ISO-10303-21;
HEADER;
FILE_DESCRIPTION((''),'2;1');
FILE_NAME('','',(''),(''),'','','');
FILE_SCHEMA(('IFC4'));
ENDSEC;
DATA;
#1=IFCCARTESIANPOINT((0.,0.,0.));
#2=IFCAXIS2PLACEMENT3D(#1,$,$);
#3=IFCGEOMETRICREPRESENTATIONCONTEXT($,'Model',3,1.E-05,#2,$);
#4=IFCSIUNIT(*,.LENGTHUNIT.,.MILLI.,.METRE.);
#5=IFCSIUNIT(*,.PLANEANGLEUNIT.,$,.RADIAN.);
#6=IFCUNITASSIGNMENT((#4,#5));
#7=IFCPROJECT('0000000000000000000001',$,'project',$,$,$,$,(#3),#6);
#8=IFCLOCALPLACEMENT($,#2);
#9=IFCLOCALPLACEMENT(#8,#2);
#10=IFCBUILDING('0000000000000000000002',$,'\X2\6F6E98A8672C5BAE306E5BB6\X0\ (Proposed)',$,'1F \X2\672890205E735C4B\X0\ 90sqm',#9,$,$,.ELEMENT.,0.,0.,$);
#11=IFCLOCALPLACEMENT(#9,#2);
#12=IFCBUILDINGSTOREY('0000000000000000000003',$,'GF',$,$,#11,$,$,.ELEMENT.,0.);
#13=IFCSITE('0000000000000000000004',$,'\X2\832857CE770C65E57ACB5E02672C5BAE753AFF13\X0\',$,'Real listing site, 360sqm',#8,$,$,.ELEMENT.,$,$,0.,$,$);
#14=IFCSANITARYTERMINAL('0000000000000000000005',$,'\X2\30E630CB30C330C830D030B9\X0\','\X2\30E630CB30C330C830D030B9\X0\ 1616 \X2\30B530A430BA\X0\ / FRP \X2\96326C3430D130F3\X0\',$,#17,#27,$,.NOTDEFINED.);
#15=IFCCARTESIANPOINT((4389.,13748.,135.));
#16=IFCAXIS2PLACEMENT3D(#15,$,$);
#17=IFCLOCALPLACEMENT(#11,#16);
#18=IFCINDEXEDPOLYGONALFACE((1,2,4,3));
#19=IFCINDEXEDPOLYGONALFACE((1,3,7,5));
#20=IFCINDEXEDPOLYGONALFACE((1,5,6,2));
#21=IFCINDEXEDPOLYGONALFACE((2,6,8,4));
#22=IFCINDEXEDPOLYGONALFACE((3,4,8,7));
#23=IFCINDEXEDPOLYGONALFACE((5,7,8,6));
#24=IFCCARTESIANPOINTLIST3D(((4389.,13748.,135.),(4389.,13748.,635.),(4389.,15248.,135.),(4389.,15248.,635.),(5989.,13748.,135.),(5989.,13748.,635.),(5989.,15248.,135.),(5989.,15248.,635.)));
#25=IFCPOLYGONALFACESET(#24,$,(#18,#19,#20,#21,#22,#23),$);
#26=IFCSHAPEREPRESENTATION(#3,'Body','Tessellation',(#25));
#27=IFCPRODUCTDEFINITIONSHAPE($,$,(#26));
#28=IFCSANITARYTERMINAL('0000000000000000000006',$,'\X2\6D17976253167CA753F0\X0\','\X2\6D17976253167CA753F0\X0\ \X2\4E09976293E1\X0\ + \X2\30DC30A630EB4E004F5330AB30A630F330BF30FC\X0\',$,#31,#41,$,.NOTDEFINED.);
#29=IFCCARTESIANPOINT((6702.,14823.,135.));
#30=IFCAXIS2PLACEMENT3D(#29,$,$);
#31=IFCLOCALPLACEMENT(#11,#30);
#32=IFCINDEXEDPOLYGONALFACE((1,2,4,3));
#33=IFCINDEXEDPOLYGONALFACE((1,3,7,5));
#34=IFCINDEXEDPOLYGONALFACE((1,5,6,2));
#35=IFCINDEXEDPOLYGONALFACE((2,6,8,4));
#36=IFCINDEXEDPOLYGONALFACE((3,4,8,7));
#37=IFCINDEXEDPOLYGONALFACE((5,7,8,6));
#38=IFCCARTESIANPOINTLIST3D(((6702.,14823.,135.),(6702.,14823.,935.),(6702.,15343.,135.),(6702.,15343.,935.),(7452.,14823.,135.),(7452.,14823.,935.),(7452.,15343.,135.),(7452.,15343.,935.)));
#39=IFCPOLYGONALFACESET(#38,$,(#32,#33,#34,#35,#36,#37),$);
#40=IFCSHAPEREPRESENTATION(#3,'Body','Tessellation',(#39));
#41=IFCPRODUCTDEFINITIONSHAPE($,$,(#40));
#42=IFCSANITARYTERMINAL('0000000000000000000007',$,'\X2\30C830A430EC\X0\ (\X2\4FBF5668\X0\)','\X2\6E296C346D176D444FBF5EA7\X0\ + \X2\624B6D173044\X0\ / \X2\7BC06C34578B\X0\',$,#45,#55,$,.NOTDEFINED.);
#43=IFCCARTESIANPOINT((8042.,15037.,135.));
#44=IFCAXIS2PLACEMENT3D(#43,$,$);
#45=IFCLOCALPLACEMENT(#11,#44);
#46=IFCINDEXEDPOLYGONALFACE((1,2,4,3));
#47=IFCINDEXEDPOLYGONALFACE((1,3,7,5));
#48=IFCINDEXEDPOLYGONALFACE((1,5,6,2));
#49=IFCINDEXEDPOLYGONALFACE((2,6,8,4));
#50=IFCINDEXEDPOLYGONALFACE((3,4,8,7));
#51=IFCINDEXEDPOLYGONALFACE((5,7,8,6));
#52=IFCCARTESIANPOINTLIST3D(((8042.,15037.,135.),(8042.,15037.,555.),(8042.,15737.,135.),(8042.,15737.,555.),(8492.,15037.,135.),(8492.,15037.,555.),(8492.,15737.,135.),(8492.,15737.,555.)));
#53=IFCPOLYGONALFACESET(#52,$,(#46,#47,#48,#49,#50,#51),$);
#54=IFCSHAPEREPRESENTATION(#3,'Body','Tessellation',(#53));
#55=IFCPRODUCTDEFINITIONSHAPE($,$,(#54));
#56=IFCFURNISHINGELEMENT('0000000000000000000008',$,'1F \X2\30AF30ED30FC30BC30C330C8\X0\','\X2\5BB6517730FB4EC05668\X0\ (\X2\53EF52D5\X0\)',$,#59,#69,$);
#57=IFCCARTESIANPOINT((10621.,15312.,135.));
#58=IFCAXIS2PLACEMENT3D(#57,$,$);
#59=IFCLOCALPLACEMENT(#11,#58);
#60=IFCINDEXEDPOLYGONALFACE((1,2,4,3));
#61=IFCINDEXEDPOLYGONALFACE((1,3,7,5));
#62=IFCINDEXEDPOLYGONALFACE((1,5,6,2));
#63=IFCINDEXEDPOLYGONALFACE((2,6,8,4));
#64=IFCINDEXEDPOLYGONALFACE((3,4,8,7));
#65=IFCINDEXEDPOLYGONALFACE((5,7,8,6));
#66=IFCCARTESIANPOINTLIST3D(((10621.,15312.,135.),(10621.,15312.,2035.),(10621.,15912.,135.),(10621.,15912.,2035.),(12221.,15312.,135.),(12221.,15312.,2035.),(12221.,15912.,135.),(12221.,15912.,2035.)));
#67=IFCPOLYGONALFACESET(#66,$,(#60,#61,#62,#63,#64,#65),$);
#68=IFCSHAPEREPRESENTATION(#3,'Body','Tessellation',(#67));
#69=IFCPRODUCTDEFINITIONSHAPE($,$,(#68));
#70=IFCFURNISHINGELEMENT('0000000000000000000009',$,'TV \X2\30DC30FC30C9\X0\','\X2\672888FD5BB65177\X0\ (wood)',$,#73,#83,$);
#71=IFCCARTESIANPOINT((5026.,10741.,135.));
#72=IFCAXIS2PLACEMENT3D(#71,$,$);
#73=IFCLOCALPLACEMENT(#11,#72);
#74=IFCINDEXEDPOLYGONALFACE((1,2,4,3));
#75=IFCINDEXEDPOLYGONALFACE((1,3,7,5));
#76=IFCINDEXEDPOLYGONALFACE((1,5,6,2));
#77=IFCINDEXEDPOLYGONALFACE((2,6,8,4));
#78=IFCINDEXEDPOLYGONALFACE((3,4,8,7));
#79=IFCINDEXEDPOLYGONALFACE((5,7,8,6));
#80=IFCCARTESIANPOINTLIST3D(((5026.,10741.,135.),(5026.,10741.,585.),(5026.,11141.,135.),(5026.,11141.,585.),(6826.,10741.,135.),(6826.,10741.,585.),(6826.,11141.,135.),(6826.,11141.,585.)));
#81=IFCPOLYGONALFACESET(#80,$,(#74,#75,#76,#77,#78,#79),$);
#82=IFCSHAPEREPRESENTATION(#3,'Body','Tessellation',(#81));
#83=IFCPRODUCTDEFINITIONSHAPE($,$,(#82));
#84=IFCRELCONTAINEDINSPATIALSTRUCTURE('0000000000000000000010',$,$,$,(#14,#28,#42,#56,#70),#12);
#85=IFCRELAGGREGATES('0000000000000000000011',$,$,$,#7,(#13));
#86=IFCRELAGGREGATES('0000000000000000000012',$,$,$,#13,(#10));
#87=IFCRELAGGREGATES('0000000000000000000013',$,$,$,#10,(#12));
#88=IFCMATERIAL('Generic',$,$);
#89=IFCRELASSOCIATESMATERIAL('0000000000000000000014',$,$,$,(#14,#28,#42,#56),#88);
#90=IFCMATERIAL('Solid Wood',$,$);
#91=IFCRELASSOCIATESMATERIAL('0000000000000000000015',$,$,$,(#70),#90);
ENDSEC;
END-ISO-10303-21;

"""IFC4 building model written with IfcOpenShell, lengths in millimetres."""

from ifc_helpers import new_model, si_unit, frame, frame_2d, origin, place, context, project, spatial, rectangle, extrude, material, element, save


model = new_model("IFC4")

# Units and contexts
model_context = context("Model", 3, precision=1e-05, world=origin())
ifc_project = project(units=[si_unit("LENGTHUNIT", "METRE", prefix="MILLI"), si_unit("PLANEANGLEUNIT", "RADIAN")], contexts=[model_context])

# Site, building, storey
site_placement = place(None, origin())
site = spatial("IfcSite", under=ifc_project, at=site_placement, Name="茨城県日立市本宮町３", ObjectType="Real listing site, 360sqm", CompositionType="ELEMENT", RefElevation=0.0)
building_placement = place(site_placement, origin())
building = spatial("IfcBuilding", under=site, at=building_placement, Name="潮風本宮の家 (Proposed)", ObjectType="1F 木造平屋 90sqm", CompositionType="ELEMENT", ElevationOfRefHeight=0.0, ElevationOfTerrain=0.0)
storey_placement = place(building_placement, origin())
storey = spatial("IfcBuildingStorey", under=building, at=storey_placement, Name="GF", CompositionType="ELEMENT", Elevation=0.0)

# Shared definitions
ifc_material_1 = material(Name="Solid Wood")

# Sanitary terminals
ifc_material_2 = material(Name="Generic")
sanitary_terminal_1_placement = place(storey_placement, frame((4389.0, 13748.0, 135.0)))
element("IfcSanitaryTerminal", 1, at=sanitary_terminal_1_placement, inside=storey, material=ifc_material_2, Name="ユニットバス", Description="ユニットバス 1616 サイズ / FRP 防水パン", PredefinedType="NOTDEFINED", context=model_context, shape_type="SweptSolid", body=[
    extrude(rectangle(XDim=1600.0, YDim=1500.0, at=frame_2d((800.0, 750.0))), frame((4389.0, 13748.0, 135.0)), (0.0, 0.0, 1.0), 500.0),
])
sanitary_terminal_2_placement = place(storey_placement, frame((6702.0, 14823.0, 135.0)))
element("IfcSanitaryTerminal", 2, at=sanitary_terminal_2_placement, inside=storey, material=ifc_material_2, Name="洗面化粧台", Description="洗面化粧台 三面鏡 + ボウル一体カウンター", PredefinedType="NOTDEFINED", context=model_context, shape_type="SweptSolid", body=[
    extrude(rectangle(XDim=750.0, YDim=520.0, at=frame_2d((375.0, 260.0))), frame((6702.0, 14823.0, 135.0)), (0.0, 0.0, 1.0), 800.0),
])
sanitary_terminal_3_placement = place(storey_placement, frame((8042.0, 15037.0, 135.0)))
element("IfcSanitaryTerminal", 3, at=sanitary_terminal_3_placement, inside=storey, material=ifc_material_2, Name="トイレ (便器)", Description="温水洗浄便座 + 手洗い / 節水型", PredefinedType="NOTDEFINED", context=model_context, shape_type="SweptSolid", body=[
    extrude(rectangle(XDim=450.0, YDim=700.0, at=frame_2d((225.0, 350.0))), frame((8042.0, 15037.0, 135.0)), (0.0, 0.0, 1.0), 420.0),
])

# Furnishing elements
furnishing_1_placement = place(storey_placement, frame((10621.0, 15312.0, 135.0)))
element("IfcFurnishingElement", 4, at=furnishing_1_placement, inside=storey, material=ifc_material_2, Name="1F クローゼット", Description="家具・什器 (可動)", context=model_context, shape_type="SweptSolid", body=[
    extrude(rectangle(XDim=1600.0, YDim=600.0, at=frame_2d((800.0, 300.0))), frame((10621.0, 15312.0, 135.0)), (0.0, 0.0, 1.0), 1900.0),
])
furnishing_2_placement = place(storey_placement, frame((5026.0, 10741.0, 135.0)))
element("IfcFurnishingElement", 5, at=furnishing_2_placement, inside=storey, material=ifc_material_1, Name="TV ボード", Description="木製家具 (wood)", context=model_context, shape_type="SweptSolid", body=[
    extrude(rectangle(XDim=1800.0, YDim=400.0, at=frame_2d((900.0, 200.0))), frame((5026.0, 10741.0, 135.0)), (0.0, 0.0, 1.0), 450.0),
])

save(model, "model.ifc")
